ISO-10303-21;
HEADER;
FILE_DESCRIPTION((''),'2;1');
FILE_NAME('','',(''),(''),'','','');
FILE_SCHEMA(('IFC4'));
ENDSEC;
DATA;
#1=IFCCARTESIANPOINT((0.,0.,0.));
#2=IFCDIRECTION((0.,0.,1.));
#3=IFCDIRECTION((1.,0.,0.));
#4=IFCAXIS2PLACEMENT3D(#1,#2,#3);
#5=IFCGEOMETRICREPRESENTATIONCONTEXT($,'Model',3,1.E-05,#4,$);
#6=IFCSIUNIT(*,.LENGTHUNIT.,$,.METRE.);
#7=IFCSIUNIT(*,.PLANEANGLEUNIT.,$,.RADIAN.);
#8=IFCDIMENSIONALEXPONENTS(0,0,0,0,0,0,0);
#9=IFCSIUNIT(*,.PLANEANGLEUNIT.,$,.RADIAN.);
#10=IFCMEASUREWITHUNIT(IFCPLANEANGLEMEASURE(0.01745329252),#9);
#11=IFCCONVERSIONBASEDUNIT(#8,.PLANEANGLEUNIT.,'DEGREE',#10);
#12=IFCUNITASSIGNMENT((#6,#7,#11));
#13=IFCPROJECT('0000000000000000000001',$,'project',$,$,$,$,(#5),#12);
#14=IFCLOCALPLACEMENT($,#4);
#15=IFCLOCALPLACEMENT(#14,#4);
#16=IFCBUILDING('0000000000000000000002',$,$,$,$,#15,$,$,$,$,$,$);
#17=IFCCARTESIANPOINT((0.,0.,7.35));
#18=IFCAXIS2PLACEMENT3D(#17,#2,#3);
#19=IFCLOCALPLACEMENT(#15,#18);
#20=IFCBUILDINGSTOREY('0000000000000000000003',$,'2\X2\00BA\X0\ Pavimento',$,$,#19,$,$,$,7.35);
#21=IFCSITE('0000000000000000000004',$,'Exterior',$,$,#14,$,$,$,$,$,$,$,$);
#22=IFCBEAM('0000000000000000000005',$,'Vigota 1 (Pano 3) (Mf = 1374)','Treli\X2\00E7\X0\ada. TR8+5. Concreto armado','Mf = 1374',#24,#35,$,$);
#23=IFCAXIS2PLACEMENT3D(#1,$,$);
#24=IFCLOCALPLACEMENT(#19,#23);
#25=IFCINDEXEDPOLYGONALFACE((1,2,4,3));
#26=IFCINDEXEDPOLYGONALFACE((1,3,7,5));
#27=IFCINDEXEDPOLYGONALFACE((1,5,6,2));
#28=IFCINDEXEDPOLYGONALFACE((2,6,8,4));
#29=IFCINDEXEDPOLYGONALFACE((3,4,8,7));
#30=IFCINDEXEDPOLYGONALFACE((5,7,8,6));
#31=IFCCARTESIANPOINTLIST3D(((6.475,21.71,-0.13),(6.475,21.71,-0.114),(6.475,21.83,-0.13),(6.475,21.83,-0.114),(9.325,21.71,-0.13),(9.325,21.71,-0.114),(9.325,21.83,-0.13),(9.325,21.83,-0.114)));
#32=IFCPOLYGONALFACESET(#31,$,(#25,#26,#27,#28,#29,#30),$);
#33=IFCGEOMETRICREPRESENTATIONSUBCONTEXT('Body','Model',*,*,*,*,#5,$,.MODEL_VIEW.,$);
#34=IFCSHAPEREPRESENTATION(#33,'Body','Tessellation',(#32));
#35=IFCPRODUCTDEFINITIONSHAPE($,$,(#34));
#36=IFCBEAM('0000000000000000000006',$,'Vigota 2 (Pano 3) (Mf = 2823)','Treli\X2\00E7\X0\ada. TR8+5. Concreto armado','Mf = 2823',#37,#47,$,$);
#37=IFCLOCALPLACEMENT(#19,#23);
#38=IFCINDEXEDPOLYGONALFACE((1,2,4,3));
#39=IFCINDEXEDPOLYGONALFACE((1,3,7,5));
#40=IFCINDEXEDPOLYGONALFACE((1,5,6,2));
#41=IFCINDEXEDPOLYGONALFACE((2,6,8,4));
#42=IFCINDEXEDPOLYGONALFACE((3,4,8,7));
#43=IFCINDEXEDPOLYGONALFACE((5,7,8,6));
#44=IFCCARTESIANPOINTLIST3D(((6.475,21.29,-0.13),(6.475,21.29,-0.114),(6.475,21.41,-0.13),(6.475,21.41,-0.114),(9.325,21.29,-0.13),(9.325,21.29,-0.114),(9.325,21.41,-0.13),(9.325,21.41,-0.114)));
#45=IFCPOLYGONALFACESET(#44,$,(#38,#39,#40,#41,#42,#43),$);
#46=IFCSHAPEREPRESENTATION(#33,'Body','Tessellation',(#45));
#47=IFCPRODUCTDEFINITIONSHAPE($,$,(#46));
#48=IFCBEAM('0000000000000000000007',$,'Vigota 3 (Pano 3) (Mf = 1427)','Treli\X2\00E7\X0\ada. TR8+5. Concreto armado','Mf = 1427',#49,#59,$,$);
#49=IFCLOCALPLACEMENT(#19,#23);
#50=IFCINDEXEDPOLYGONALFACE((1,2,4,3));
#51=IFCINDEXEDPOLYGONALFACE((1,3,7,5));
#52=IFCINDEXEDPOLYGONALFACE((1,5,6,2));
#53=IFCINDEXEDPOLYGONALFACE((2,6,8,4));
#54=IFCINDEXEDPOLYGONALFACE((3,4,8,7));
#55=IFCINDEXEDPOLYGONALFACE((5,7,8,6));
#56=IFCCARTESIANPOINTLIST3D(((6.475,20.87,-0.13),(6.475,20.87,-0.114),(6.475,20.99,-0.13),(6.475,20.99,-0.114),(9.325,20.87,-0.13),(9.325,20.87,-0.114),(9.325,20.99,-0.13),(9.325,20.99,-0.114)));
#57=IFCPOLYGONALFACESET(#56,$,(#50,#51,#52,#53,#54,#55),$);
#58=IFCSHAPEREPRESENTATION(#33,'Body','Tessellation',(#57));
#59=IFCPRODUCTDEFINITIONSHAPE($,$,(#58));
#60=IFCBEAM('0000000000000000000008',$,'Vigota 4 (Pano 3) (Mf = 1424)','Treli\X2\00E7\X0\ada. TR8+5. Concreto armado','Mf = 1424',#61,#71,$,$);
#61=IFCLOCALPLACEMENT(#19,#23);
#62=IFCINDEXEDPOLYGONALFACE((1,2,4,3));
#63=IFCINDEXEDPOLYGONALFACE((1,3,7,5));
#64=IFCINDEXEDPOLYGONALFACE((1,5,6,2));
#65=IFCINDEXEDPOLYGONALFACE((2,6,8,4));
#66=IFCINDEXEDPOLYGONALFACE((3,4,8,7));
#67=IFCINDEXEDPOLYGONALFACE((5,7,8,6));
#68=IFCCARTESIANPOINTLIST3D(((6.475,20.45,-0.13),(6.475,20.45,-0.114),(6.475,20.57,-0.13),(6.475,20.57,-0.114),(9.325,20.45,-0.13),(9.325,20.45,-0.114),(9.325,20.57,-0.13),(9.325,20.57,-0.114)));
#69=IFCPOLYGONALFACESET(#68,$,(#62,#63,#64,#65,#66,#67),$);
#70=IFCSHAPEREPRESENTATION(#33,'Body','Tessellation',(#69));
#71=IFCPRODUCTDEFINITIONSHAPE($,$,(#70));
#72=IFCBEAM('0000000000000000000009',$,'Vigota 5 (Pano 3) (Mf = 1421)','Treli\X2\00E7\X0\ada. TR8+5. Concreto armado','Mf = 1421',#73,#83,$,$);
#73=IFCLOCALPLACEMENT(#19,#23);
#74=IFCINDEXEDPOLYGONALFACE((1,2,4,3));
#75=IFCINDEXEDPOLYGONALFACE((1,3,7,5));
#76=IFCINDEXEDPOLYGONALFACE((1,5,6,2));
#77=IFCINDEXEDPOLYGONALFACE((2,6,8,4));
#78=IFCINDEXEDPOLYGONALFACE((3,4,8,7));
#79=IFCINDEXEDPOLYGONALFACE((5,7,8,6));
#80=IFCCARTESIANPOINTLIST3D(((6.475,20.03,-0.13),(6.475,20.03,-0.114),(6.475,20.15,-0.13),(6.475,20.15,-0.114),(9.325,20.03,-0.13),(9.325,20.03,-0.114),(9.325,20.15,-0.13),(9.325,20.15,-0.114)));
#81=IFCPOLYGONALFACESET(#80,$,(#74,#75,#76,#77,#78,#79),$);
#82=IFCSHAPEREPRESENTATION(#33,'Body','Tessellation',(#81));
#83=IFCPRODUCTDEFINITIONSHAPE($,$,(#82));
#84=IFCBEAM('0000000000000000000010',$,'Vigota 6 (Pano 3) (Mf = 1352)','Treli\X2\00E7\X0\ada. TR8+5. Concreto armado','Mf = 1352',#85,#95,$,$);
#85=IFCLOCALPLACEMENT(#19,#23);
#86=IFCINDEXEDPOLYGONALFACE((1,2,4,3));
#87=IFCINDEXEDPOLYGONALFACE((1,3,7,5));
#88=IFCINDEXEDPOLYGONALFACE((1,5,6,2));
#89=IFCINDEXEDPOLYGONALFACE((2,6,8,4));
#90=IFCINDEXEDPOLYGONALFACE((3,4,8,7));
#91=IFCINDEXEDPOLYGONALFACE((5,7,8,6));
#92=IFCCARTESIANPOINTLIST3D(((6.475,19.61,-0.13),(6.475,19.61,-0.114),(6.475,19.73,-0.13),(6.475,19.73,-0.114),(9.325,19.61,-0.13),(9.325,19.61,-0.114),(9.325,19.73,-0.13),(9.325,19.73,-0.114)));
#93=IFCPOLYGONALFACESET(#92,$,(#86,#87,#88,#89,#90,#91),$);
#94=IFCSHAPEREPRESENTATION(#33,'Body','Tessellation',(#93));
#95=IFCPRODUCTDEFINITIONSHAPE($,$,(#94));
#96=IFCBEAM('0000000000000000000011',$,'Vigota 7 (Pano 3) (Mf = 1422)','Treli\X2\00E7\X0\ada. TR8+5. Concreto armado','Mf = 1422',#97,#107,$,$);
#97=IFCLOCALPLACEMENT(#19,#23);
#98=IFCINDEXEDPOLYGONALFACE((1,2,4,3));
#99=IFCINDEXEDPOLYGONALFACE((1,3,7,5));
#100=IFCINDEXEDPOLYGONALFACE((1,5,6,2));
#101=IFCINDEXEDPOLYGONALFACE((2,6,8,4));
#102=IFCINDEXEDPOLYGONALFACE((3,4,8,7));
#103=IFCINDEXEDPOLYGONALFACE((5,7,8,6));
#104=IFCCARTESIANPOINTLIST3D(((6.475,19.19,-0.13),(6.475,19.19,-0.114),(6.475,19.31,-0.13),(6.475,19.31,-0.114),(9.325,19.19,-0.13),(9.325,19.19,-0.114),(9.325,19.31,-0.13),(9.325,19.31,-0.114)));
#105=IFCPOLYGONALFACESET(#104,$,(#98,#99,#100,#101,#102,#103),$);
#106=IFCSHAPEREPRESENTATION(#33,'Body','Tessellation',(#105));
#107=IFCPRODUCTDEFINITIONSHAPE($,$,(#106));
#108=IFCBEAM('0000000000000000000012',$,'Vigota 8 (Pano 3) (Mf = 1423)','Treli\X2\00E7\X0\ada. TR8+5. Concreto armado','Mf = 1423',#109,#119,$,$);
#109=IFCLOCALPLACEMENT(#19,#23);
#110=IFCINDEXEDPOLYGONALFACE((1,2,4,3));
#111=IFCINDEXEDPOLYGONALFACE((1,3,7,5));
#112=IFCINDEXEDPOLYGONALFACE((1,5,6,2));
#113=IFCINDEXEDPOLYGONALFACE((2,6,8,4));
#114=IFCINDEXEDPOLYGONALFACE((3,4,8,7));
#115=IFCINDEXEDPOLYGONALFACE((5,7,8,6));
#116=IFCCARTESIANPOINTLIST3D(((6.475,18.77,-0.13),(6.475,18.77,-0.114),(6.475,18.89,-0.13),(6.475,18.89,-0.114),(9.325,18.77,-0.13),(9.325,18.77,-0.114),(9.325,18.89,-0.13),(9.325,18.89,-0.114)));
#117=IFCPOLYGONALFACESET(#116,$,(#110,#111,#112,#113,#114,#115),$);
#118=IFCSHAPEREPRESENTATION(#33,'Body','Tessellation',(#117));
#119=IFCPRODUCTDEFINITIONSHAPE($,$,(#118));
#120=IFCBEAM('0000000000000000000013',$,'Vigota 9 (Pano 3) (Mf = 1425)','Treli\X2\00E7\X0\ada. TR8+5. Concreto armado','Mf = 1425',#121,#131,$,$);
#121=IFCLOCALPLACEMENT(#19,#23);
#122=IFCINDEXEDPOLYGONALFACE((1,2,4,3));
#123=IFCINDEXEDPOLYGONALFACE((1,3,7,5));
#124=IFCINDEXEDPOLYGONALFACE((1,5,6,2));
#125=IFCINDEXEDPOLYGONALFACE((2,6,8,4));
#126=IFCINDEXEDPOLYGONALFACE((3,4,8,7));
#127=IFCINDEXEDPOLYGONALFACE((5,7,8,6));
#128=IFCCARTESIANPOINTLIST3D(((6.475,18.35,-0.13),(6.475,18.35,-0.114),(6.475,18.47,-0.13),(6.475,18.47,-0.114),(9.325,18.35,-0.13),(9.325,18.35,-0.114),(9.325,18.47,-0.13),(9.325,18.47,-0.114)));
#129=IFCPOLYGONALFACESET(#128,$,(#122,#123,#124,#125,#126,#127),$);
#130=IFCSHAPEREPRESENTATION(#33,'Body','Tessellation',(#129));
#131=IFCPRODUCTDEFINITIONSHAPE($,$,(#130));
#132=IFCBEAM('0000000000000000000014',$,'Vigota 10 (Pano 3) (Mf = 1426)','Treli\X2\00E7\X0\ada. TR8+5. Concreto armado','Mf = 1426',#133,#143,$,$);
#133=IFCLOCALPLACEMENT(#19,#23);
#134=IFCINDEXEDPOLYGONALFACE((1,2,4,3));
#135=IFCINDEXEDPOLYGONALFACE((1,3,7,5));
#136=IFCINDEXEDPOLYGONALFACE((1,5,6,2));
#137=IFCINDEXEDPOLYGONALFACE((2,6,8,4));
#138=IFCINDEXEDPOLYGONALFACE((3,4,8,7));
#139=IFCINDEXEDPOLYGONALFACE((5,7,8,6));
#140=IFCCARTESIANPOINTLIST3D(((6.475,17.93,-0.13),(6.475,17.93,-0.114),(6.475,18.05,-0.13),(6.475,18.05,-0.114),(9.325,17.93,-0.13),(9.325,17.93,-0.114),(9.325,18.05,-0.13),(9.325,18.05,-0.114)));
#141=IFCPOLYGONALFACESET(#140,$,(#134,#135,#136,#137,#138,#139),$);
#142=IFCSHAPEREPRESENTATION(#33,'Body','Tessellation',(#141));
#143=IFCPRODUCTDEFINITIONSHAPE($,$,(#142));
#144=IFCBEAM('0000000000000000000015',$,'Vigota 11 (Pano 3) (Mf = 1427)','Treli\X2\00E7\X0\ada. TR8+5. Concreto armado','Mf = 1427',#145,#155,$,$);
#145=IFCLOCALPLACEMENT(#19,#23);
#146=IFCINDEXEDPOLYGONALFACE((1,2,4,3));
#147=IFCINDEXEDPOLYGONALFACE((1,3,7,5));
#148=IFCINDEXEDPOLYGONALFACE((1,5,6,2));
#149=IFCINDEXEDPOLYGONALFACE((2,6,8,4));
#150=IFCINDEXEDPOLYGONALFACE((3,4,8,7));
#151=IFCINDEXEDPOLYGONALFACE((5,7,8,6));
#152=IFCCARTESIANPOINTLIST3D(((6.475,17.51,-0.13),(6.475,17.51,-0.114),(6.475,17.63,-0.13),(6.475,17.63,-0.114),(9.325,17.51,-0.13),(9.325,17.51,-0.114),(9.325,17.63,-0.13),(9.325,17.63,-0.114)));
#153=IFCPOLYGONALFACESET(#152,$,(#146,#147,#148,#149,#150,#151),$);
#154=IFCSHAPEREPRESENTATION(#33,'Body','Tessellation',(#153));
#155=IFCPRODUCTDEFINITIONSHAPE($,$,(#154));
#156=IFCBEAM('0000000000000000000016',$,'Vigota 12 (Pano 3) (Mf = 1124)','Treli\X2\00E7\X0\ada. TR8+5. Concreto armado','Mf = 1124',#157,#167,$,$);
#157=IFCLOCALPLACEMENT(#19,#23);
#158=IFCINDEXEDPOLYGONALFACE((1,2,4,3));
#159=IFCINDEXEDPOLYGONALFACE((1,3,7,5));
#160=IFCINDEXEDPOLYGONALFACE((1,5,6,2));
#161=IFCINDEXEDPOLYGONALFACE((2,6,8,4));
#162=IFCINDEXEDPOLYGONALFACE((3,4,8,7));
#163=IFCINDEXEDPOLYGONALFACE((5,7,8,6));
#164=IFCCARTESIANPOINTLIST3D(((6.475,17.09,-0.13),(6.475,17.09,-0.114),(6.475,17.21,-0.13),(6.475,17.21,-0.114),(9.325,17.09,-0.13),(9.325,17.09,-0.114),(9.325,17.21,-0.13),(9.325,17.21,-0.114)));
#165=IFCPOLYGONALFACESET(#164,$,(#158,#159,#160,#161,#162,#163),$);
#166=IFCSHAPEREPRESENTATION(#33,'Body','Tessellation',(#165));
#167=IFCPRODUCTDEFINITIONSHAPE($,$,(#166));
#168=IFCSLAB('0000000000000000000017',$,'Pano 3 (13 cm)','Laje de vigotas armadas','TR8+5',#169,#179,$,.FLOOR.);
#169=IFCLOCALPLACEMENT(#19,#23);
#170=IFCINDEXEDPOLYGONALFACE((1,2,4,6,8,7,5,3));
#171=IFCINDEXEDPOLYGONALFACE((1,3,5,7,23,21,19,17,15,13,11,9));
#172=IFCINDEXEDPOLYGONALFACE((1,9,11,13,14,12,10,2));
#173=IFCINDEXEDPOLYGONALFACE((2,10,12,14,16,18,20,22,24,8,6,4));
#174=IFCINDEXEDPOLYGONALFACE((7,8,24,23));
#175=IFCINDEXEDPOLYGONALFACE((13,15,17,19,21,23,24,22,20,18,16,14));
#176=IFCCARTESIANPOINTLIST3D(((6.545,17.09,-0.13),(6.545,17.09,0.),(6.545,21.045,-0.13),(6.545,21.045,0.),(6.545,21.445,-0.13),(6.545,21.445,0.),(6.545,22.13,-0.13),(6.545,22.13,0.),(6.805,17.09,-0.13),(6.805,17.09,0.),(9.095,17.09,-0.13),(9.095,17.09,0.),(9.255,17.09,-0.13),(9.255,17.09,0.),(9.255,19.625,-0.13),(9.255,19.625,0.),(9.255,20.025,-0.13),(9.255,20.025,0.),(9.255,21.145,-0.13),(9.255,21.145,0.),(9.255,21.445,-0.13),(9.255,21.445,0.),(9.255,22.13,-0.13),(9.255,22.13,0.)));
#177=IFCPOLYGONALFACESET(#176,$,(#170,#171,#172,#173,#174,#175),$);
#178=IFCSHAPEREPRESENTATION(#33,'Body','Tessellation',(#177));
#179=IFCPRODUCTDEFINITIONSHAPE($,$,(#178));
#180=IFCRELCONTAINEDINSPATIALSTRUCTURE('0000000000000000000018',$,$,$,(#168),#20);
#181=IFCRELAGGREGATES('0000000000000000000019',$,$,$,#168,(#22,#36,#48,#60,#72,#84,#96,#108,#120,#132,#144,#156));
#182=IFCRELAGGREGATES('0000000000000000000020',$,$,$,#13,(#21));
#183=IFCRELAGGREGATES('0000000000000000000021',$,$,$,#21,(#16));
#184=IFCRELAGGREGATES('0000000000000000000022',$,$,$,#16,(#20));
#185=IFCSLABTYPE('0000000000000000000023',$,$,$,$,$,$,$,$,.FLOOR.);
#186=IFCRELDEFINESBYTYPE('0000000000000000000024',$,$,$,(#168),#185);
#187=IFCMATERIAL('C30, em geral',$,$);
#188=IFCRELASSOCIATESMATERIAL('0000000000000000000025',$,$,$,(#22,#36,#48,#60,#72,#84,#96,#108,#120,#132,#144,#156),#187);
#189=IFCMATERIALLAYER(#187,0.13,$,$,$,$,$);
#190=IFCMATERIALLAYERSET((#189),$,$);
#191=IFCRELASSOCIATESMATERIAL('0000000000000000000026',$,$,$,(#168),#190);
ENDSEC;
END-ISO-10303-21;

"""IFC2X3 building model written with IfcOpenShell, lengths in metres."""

from ifc_helpers import new_model, entity, si_unit, converted_unit, frame, origin_with_axes, place, context, subcontext, project, spatial, polyline, outline, extrude, material, layer, layer_set, layer_usage, type_object, element, aggregate, save


model = new_model("IFC2X3")

# Units and contexts
model_context = context("Model", 3, precision=1e-05, world=origin_with_axes())
body_context = subcontext(model_context, "Body", "Model", "MODEL_VIEW")
ifc_project = project(units=[si_unit("LENGTHUNIT", "METRE"), si_unit("PLANEANGLEUNIT", "RADIAN"), converted_unit("PLANEANGLEUNIT", "DEGREE", entity("IfcPlaneAngleMeasure", 0.01745329252), si_unit("PLANEANGLEUNIT", "RADIAN"), dimensions=[0, 0, 0, 0, 0, 0, 0])], contexts=[model_context])

# Beams
ifc_material = material(Name="C30, em geral")
site_placement = place(None, origin_with_axes())
building_placement = place(site_placement, origin_with_axes())
storey_placement = place(building_placement, frame((0.0, 0.0, 7.35), z_axis=(0.0, 0.0, 1.0), x_axis=(1.0, 0.0, 0.0)))
beam_1_placement = place(storey_placement, frame((6.475, 21.77, -0.122), z_axis=(1.0, 0.0, 0.0), x_axis=(0.0, 1.0, 0.0)))
beam_1 = element("IfcBeam", 1, at=beam_1_placement, material=ifc_material, Name="Vigota 1 (Pano 3) (Mf = 1374)", Description="Treliçada. TR8+5. Concreto armado", ObjectType="Mf = 1374", context=body_context, shape_type="SweptSolid", body=[
    extrude(outline(polyline([(0.06, 0.008), (-0.06, 0.008), (-0.06, -0.008), (0.06, -0.008), (0.06, 0.008)])), origin_with_axes(), (0.0, 0.0, 1.0), 2.85),
])
beam_2_placement = place(storey_placement, frame((6.475, 21.35, -0.122), z_axis=(1.0, 0.0, 0.0), x_axis=(0.0, 1.0, 0.0)))
beam_2 = element("IfcBeam", 2, at=beam_2_placement, material=ifc_material, Name="Vigota 2 (Pano 3) (Mf = 2823)", Description="Treliçada. TR8+5. Concreto armado", ObjectType="Mf = 2823", context=body_context, shape_type="SweptSolid", body=[
    extrude(outline(polyline([(0.06, 0.008), (-0.06, 0.008), (-0.06, -0.008), (0.06, -0.008), (0.06, 0.008)])), origin_with_axes(), (0.0, 0.0, 1.0), 2.85),
])
beam_3_placement = place(storey_placement, frame((6.475, 20.93, -0.122), z_axis=(1.0, 0.0, 0.0), x_axis=(0.0, 1.0, 0.0)))
beam_3 = element("IfcBeam", 3, at=beam_3_placement, material=ifc_material, Name="Vigota 3 (Pano 3) (Mf = 1427)", Description="Treliçada. TR8+5. Concreto armado", ObjectType="Mf = 1427", context=body_context, shape_type="SweptSolid", body=[
    extrude(outline(polyline([(0.06, 0.008), (-0.06, 0.008), (-0.06, -0.008), (0.06, -0.008), (0.06, 0.008)])), origin_with_axes(), (0.0, 0.0, 1.0), 2.85),
])
beam_4_placement = place(storey_placement, frame((6.475, 20.51, -0.122), z_axis=(1.0, 0.0, 0.0), x_axis=(0.0, 1.0, 0.0)))
beam_4 = element("IfcBeam", 4, at=beam_4_placement, material=ifc_material, Name="Vigota 4 (Pano 3) (Mf = 1424)", Description="Treliçada. TR8+5. Concreto armado", ObjectType="Mf = 1424", context=body_context, shape_type="SweptSolid", body=[
    extrude(outline(polyline([(0.06, 0.008), (-0.06, 0.008), (-0.06, -0.008), (0.06, -0.008), (0.06, 0.008)])), origin_with_axes(), (0.0, 0.0, 1.0), 2.85),
])
beam_5_placement = place(storey_placement, frame((6.475, 20.09, -0.122), z_axis=(1.0, 0.0, 0.0), x_axis=(0.0, 1.0, 0.0)))
beam_5 = element("IfcBeam", 5, at=beam_5_placement, material=ifc_material, Name="Vigota 5 (Pano 3) (Mf = 1421)", Description="Treliçada. TR8+5. Concreto armado", ObjectType="Mf = 1421", context=body_context, shape_type="SweptSolid", body=[
    extrude(outline(polyline([(0.06, 0.008), (-0.06, 0.008), (-0.06, -0.008), (0.06, -0.008), (0.06, 0.008)])), origin_with_axes(), (0.0, 0.0, 1.0), 2.85),
])
beam_6_placement = place(storey_placement, frame((6.475, 19.67, -0.122), z_axis=(1.0, 0.0, 0.0), x_axis=(0.0, 1.0, 0.0)))
beam_6 = element("IfcBeam", 6, at=beam_6_placement, material=ifc_material, Name="Vigota 6 (Pano 3) (Mf = 1352)", Description="Treliçada. TR8+5. Concreto armado", ObjectType="Mf = 1352", context=body_context, shape_type="SweptSolid", body=[
    extrude(outline(polyline([(0.06, 0.008), (-0.06, 0.008), (-0.06, -0.008), (0.06, -0.008), (0.06, 0.008)])), origin_with_axes(), (0.0, 0.0, 1.0), 2.85),
])
beam_7_placement = place(storey_placement, frame((6.475, 19.25, -0.122), z_axis=(1.0, 0.0, 0.0), x_axis=(0.0, 1.0, 0.0)))
beam_7 = element("IfcBeam", 7, at=beam_7_placement, material=ifc_material, Name="Vigota 7 (Pano 3) (Mf = 1422)", Description="Treliçada. TR8+5. Concreto armado", ObjectType="Mf = 1422", context=body_context, shape_type="SweptSolid", body=[
    extrude(outline(polyline([(0.06, 0.008), (-0.06, 0.008), (-0.06, -0.008), (0.06, -0.008), (0.06, 0.008)])), origin_with_axes(), (0.0, 0.0, 1.0), 2.85),
])
beam_8_placement = place(storey_placement, frame((6.475, 18.83, -0.122), z_axis=(1.0, 0.0, 0.0), x_axis=(0.0, 1.0, 0.0)))
beam_8 = element("IfcBeam", 8, at=beam_8_placement, material=ifc_material, Name="Vigota 8 (Pano 3) (Mf = 1423)", Description="Treliçada. TR8+5. Concreto armado", ObjectType="Mf = 1423", context=body_context, shape_type="SweptSolid", body=[
    extrude(outline(polyline([(0.06, 0.008), (-0.06, 0.008), (-0.06, -0.008), (0.06, -0.008), (0.06, 0.008)])), origin_with_axes(), (0.0, 0.0, 1.0), 2.85),
])
beam_9_placement = place(storey_placement, frame((6.475, 18.41, -0.122), z_axis=(1.0, 0.0, 0.0), x_axis=(0.0, 1.0, 0.0)))
beam_9 = element("IfcBeam", 9, at=beam_9_placement, material=ifc_material, Name="Vigota 9 (Pano 3) (Mf = 1425)", Description="Treliçada. TR8+5. Concreto armado", ObjectType="Mf = 1425", context=body_context, shape_type="SweptSolid", body=[
    extrude(outline(polyline([(0.06, 0.008), (-0.06, 0.008), (-0.06, -0.008), (0.06, -0.008), (0.06, 0.008)])), origin_with_axes(), (0.0, 0.0, 1.0), 2.85),
])
beam_10_placement = place(storey_placement, frame((6.475, 17.99, -0.122), z_axis=(1.0, 0.0, 0.0), x_axis=(0.0, 1.0, 0.0)))
beam_10 = element("IfcBeam", 10, at=beam_10_placement, material=ifc_material, Name="Vigota 10 (Pano 3) (Mf = 1426)", Description="Treliçada. TR8+5. Concreto armado", ObjectType="Mf = 1426", context=body_context, shape_type="SweptSolid", body=[
    extrude(outline(polyline([(0.06, 0.008), (-0.06, 0.008), (-0.06, -0.008), (0.06, -0.008), (0.06, 0.008)])), origin_with_axes(), (0.0, 0.0, 1.0), 2.85),
])
beam_11_placement = place(storey_placement, frame((6.475, 17.57, -0.122), z_axis=(1.0, 0.0, 0.0), x_axis=(0.0, 1.0, 0.0)))
beam_11 = element("IfcBeam", 11, at=beam_11_placement, material=ifc_material, Name="Vigota 11 (Pano 3) (Mf = 1427)", Description="Treliçada. TR8+5. Concreto armado", ObjectType="Mf = 1427", context=body_context, shape_type="SweptSolid", body=[
    extrude(outline(polyline([(0.06, 0.008), (-0.06, 0.008), (-0.06, -0.008), (0.06, -0.008), (0.06, 0.008)])), origin_with_axes(), (0.0, 0.0, 1.0), 2.85),
])
beam_12_placement = place(storey_placement, frame((6.475, 17.15, -0.122), z_axis=(1.0, 0.0, 0.0), x_axis=(0.0, 1.0, 0.0)))
beam_12 = element("IfcBeam", 12, at=beam_12_placement, material=ifc_material, Name="Vigota 12 (Pano 3) (Mf = 1124)", Description="Treliçada. TR8+5. Concreto armado", ObjectType="Mf = 1124", context=body_context, shape_type="SweptSolid", body=[
    extrude(outline(polyline([(0.06, 0.008), (-0.06, 0.008), (-0.06, -0.008), (0.06, -0.008), (0.06, 0.008)])), origin_with_axes(), (0.0, 0.0, 1.0), 2.85),
])

# Site, building, storey
site = spatial("IfcSite", under=ifc_project, at=site_placement, Name="Exterior")
building = spatial("IfcBuilding", under=site, at=building_placement)
storey = spatial("IfcBuildingStorey", under=building, at=storey_placement, Name="2º Pavimento", Elevation=7.35)

# Slab
slab_type = type_object("IfcSlabType", PredefinedType="FLOOR")
ifc_layer_1 = layer(ifc_material, 0.13)
ifc_layer_set_1 = layer_set([ifc_layer_1])
ifc_layer_usage_1 = layer_usage(ifc_layer_set_1, "AXIS3", "POSITIVE", 0.0)
slab_1_placement = place(storey_placement, frame((0.0, 0.0, -0.13), z_axis=(0.0, 0.0, 1.0), x_axis=(1.0, 0.0, 0.0)))
slab_1 = element("IfcSlab", 13, at=slab_1_placement, inside=storey, type_object=slab_type, material=ifc_layer_usage_1, Name="Pano 3 (13 cm)", Description="Laje de vigotas armadas", ObjectType="TR8+5", PredefinedType="FLOOR", context=body_context, shape_type="SweptSolid", body=[
    extrude(outline(polyline([(9.255, 17.09), (9.255, 19.625), (9.255, 20.025), (9.255, 21.145), (9.255, 21.445), (9.255, 22.13), (6.545, 22.13), (6.545, 21.445), (6.545, 21.045), (6.545, 17.09), (6.805, 17.09), (9.095, 17.09), (9.255, 17.09)])), origin_with_axes(), (0.0, 0.0, 1.0), 0.13),
])
aggregate(slab_1, [beam_1, beam_2, beam_3, beam_4, beam_5, beam_6, beam_7, beam_8, beam_9, beam_10, beam_11, beam_12])

save(model, "model.ifc")
